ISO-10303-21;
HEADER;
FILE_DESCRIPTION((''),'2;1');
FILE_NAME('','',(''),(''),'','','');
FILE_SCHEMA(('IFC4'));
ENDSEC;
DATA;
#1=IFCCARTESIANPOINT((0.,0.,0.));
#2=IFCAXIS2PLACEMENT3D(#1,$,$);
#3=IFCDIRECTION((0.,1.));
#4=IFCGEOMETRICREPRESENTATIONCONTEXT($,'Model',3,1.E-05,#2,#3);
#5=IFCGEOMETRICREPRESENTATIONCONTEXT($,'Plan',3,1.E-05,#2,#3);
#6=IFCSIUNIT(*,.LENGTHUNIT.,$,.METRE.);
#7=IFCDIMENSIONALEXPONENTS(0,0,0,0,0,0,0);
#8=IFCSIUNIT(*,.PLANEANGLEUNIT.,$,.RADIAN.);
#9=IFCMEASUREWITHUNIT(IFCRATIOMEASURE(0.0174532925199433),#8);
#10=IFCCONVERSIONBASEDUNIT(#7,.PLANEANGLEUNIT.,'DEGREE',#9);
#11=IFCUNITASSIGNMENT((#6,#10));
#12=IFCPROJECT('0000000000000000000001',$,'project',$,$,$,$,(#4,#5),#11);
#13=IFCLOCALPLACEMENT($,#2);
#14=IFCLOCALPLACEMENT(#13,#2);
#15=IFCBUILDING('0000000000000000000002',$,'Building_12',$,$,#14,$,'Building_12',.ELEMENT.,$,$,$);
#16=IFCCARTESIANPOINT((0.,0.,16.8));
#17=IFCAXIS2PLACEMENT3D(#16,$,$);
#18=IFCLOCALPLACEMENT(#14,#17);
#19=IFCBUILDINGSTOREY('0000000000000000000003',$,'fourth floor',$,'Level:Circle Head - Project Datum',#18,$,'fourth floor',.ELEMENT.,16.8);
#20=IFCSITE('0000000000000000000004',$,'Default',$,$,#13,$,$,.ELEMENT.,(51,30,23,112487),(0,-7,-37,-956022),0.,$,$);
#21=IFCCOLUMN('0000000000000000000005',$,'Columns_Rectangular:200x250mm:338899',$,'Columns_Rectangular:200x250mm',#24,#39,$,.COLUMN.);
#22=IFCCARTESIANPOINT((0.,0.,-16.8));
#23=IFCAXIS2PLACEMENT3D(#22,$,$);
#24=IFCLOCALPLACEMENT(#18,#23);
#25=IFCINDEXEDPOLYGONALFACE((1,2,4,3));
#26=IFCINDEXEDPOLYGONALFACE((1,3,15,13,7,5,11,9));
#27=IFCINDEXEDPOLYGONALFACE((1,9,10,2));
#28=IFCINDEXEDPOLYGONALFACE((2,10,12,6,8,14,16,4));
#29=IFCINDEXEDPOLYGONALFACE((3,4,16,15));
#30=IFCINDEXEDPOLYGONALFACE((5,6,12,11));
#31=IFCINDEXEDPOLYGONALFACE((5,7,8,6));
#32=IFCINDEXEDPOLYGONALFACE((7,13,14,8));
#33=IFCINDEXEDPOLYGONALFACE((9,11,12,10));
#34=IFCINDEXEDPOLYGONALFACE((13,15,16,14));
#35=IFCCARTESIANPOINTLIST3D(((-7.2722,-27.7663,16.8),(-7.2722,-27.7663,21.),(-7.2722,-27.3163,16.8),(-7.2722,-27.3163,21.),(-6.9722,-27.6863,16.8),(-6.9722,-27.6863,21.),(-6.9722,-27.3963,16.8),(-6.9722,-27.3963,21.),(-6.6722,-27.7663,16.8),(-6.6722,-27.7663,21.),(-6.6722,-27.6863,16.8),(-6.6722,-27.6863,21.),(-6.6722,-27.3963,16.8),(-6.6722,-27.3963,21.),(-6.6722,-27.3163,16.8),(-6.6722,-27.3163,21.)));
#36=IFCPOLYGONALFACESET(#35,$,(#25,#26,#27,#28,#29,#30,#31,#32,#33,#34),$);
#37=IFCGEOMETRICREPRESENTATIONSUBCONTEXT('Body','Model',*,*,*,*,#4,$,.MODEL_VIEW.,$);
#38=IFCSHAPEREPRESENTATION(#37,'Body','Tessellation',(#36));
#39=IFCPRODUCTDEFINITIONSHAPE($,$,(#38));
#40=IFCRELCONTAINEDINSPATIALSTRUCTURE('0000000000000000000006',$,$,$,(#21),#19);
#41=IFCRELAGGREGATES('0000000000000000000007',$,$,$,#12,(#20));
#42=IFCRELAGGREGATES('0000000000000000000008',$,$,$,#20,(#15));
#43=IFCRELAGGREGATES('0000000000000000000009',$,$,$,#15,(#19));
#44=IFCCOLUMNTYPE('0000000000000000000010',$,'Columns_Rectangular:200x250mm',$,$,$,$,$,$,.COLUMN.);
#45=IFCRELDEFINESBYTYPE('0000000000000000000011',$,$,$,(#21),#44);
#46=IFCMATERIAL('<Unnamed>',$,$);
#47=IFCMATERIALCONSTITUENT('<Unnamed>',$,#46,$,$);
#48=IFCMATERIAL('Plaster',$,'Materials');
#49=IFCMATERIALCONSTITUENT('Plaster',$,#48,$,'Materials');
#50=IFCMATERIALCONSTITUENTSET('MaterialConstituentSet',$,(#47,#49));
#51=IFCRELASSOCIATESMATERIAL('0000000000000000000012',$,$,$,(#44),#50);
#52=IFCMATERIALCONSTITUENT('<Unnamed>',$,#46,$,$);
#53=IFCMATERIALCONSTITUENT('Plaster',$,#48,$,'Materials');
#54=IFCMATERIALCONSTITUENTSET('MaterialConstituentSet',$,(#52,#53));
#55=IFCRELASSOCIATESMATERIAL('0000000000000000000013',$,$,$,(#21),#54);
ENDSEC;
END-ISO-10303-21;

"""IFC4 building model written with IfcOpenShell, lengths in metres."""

from ifc_helpers import new_model, entity, si_unit, converted_unit, direction, frame, origin, place, context, subcontext, project, spatial, indexed_curve, outline, extrude, source, transform, mapped, material, constituent, constituent_set, type_object, type_shapes, element, save


model = new_model("IFC4")

# Units and contexts
model_context = context("Model", 3, precision=1e-05, world=origin(), true_north=direction((0.0, 1.0)))
plan_context = context("Plan", 3, precision=1e-05, world=origin(), true_north=direction((0.0, 1.0)))
body_context = subcontext(model_context, "Body", "Model", "MODEL_VIEW")
ifc_project = project(units=[si_unit("LENGTHUNIT", "METRE"), converted_unit("PLANEANGLEUNIT", "DEGREE", entity("IfcRatioMeasure", 0.0174532925199433), si_unit("PLANEANGLEUNIT", "RADIAN"), dimensions=[0, 0, 0, 0, 0, 0, 0])], contexts=[model_context, plan_context])

# Site, building, storey
site_placement = place(None, origin())
site = spatial("IfcSite", under=ifc_project, at=site_placement, Name="Default", CompositionType="ELEMENT", RefLatitude=(51, 30, 23, 112487), RefLongitude=(0, -7, -37, -956022), RefElevation=0.0)
building_placement = place(site_placement, origin())
building = spatial("IfcBuilding", under=site, at=building_placement, Name="Building_12", LongName="Building_12", CompositionType="ELEMENT")
storey_placement = place(building_placement, frame((0.0, 0.0, 16.8)))
storey = spatial("IfcBuildingStorey", under=building, at=storey_placement, Name="fourth floor", ObjectType="Level:Circle Head - Project Datum", LongName="fourth floor", CompositionType="ELEMENT", Elevation=16.8)

# Column
ifc_material_1 = material(Name="<Unnamed>")
ifc_material_2 = material(Name="Plaster", Category="Materials")
ifc_constituent_1 = constituent(ifc_material_1, Name="<Unnamed>")
ifc_constituent_2 = constituent(ifc_material_2, Name="Plaster", Category="Materials")
ifc_constituent_set_1 = constituent_set(constituents=[ifc_constituent_1, ifc_constituent_2], Name="MaterialConstituentSet")
ifc_constituent_3 = constituent(ifc_material_1, Name="<Unnamed>")
ifc_constituent_4 = constituent(ifc_material_2, Name="Plaster", Category="Materials")
ifc_constituent_set_2 = constituent_set(constituents=[ifc_constituent_3, ifc_constituent_4], Name="MaterialConstituentSet")
column_type_1 = type_object("IfcColumnType", Name="Columns_Rectangular:200x250mm", PredefinedType="COLUMN", material=ifc_constituent_set_2)
shared_shape_1 = source(origin(), body_context, "Body", "SweptSolid", [
    extrude(outline(indexed_curve([(-0.225, -0.375), (0.225, -0.375), (0.225, 0.225), (0.145, 0.225), (0.145, -0.075), (-0.145, -0.075), (-0.145, 0.225), (-0.225, 0.225), (-0.225, -0.375)], self_intersect=False)), frame((-6.8972, -27.5413, 16.8), z_axis=(0.0, 0.0, 1.0), x_axis=(0.0, -1.0, 0.0)), (0.0, 0.0, 1.0), 4.2),
])
type_shapes(column_type_1, [shared_shape_1])
column_1_placement = place(storey_placement, frame((0.0, 0.0, -16.8)))
element("IfcColumn", 1, at=column_1_placement, inside=storey, type_object=column_type_1, material=ifc_constituent_set_1, Name="Columns_Rectangular:200x250mm:338899", ObjectType="Columns_Rectangular:200x250mm", PredefinedType="COLUMN", context=body_context, shape_type="MappedRepresentation", body=[
    mapped(shared_shape_1, transform((0.0, 0.0, 0.0), scale=1.0)),
])

save(model, "model.ifc")
